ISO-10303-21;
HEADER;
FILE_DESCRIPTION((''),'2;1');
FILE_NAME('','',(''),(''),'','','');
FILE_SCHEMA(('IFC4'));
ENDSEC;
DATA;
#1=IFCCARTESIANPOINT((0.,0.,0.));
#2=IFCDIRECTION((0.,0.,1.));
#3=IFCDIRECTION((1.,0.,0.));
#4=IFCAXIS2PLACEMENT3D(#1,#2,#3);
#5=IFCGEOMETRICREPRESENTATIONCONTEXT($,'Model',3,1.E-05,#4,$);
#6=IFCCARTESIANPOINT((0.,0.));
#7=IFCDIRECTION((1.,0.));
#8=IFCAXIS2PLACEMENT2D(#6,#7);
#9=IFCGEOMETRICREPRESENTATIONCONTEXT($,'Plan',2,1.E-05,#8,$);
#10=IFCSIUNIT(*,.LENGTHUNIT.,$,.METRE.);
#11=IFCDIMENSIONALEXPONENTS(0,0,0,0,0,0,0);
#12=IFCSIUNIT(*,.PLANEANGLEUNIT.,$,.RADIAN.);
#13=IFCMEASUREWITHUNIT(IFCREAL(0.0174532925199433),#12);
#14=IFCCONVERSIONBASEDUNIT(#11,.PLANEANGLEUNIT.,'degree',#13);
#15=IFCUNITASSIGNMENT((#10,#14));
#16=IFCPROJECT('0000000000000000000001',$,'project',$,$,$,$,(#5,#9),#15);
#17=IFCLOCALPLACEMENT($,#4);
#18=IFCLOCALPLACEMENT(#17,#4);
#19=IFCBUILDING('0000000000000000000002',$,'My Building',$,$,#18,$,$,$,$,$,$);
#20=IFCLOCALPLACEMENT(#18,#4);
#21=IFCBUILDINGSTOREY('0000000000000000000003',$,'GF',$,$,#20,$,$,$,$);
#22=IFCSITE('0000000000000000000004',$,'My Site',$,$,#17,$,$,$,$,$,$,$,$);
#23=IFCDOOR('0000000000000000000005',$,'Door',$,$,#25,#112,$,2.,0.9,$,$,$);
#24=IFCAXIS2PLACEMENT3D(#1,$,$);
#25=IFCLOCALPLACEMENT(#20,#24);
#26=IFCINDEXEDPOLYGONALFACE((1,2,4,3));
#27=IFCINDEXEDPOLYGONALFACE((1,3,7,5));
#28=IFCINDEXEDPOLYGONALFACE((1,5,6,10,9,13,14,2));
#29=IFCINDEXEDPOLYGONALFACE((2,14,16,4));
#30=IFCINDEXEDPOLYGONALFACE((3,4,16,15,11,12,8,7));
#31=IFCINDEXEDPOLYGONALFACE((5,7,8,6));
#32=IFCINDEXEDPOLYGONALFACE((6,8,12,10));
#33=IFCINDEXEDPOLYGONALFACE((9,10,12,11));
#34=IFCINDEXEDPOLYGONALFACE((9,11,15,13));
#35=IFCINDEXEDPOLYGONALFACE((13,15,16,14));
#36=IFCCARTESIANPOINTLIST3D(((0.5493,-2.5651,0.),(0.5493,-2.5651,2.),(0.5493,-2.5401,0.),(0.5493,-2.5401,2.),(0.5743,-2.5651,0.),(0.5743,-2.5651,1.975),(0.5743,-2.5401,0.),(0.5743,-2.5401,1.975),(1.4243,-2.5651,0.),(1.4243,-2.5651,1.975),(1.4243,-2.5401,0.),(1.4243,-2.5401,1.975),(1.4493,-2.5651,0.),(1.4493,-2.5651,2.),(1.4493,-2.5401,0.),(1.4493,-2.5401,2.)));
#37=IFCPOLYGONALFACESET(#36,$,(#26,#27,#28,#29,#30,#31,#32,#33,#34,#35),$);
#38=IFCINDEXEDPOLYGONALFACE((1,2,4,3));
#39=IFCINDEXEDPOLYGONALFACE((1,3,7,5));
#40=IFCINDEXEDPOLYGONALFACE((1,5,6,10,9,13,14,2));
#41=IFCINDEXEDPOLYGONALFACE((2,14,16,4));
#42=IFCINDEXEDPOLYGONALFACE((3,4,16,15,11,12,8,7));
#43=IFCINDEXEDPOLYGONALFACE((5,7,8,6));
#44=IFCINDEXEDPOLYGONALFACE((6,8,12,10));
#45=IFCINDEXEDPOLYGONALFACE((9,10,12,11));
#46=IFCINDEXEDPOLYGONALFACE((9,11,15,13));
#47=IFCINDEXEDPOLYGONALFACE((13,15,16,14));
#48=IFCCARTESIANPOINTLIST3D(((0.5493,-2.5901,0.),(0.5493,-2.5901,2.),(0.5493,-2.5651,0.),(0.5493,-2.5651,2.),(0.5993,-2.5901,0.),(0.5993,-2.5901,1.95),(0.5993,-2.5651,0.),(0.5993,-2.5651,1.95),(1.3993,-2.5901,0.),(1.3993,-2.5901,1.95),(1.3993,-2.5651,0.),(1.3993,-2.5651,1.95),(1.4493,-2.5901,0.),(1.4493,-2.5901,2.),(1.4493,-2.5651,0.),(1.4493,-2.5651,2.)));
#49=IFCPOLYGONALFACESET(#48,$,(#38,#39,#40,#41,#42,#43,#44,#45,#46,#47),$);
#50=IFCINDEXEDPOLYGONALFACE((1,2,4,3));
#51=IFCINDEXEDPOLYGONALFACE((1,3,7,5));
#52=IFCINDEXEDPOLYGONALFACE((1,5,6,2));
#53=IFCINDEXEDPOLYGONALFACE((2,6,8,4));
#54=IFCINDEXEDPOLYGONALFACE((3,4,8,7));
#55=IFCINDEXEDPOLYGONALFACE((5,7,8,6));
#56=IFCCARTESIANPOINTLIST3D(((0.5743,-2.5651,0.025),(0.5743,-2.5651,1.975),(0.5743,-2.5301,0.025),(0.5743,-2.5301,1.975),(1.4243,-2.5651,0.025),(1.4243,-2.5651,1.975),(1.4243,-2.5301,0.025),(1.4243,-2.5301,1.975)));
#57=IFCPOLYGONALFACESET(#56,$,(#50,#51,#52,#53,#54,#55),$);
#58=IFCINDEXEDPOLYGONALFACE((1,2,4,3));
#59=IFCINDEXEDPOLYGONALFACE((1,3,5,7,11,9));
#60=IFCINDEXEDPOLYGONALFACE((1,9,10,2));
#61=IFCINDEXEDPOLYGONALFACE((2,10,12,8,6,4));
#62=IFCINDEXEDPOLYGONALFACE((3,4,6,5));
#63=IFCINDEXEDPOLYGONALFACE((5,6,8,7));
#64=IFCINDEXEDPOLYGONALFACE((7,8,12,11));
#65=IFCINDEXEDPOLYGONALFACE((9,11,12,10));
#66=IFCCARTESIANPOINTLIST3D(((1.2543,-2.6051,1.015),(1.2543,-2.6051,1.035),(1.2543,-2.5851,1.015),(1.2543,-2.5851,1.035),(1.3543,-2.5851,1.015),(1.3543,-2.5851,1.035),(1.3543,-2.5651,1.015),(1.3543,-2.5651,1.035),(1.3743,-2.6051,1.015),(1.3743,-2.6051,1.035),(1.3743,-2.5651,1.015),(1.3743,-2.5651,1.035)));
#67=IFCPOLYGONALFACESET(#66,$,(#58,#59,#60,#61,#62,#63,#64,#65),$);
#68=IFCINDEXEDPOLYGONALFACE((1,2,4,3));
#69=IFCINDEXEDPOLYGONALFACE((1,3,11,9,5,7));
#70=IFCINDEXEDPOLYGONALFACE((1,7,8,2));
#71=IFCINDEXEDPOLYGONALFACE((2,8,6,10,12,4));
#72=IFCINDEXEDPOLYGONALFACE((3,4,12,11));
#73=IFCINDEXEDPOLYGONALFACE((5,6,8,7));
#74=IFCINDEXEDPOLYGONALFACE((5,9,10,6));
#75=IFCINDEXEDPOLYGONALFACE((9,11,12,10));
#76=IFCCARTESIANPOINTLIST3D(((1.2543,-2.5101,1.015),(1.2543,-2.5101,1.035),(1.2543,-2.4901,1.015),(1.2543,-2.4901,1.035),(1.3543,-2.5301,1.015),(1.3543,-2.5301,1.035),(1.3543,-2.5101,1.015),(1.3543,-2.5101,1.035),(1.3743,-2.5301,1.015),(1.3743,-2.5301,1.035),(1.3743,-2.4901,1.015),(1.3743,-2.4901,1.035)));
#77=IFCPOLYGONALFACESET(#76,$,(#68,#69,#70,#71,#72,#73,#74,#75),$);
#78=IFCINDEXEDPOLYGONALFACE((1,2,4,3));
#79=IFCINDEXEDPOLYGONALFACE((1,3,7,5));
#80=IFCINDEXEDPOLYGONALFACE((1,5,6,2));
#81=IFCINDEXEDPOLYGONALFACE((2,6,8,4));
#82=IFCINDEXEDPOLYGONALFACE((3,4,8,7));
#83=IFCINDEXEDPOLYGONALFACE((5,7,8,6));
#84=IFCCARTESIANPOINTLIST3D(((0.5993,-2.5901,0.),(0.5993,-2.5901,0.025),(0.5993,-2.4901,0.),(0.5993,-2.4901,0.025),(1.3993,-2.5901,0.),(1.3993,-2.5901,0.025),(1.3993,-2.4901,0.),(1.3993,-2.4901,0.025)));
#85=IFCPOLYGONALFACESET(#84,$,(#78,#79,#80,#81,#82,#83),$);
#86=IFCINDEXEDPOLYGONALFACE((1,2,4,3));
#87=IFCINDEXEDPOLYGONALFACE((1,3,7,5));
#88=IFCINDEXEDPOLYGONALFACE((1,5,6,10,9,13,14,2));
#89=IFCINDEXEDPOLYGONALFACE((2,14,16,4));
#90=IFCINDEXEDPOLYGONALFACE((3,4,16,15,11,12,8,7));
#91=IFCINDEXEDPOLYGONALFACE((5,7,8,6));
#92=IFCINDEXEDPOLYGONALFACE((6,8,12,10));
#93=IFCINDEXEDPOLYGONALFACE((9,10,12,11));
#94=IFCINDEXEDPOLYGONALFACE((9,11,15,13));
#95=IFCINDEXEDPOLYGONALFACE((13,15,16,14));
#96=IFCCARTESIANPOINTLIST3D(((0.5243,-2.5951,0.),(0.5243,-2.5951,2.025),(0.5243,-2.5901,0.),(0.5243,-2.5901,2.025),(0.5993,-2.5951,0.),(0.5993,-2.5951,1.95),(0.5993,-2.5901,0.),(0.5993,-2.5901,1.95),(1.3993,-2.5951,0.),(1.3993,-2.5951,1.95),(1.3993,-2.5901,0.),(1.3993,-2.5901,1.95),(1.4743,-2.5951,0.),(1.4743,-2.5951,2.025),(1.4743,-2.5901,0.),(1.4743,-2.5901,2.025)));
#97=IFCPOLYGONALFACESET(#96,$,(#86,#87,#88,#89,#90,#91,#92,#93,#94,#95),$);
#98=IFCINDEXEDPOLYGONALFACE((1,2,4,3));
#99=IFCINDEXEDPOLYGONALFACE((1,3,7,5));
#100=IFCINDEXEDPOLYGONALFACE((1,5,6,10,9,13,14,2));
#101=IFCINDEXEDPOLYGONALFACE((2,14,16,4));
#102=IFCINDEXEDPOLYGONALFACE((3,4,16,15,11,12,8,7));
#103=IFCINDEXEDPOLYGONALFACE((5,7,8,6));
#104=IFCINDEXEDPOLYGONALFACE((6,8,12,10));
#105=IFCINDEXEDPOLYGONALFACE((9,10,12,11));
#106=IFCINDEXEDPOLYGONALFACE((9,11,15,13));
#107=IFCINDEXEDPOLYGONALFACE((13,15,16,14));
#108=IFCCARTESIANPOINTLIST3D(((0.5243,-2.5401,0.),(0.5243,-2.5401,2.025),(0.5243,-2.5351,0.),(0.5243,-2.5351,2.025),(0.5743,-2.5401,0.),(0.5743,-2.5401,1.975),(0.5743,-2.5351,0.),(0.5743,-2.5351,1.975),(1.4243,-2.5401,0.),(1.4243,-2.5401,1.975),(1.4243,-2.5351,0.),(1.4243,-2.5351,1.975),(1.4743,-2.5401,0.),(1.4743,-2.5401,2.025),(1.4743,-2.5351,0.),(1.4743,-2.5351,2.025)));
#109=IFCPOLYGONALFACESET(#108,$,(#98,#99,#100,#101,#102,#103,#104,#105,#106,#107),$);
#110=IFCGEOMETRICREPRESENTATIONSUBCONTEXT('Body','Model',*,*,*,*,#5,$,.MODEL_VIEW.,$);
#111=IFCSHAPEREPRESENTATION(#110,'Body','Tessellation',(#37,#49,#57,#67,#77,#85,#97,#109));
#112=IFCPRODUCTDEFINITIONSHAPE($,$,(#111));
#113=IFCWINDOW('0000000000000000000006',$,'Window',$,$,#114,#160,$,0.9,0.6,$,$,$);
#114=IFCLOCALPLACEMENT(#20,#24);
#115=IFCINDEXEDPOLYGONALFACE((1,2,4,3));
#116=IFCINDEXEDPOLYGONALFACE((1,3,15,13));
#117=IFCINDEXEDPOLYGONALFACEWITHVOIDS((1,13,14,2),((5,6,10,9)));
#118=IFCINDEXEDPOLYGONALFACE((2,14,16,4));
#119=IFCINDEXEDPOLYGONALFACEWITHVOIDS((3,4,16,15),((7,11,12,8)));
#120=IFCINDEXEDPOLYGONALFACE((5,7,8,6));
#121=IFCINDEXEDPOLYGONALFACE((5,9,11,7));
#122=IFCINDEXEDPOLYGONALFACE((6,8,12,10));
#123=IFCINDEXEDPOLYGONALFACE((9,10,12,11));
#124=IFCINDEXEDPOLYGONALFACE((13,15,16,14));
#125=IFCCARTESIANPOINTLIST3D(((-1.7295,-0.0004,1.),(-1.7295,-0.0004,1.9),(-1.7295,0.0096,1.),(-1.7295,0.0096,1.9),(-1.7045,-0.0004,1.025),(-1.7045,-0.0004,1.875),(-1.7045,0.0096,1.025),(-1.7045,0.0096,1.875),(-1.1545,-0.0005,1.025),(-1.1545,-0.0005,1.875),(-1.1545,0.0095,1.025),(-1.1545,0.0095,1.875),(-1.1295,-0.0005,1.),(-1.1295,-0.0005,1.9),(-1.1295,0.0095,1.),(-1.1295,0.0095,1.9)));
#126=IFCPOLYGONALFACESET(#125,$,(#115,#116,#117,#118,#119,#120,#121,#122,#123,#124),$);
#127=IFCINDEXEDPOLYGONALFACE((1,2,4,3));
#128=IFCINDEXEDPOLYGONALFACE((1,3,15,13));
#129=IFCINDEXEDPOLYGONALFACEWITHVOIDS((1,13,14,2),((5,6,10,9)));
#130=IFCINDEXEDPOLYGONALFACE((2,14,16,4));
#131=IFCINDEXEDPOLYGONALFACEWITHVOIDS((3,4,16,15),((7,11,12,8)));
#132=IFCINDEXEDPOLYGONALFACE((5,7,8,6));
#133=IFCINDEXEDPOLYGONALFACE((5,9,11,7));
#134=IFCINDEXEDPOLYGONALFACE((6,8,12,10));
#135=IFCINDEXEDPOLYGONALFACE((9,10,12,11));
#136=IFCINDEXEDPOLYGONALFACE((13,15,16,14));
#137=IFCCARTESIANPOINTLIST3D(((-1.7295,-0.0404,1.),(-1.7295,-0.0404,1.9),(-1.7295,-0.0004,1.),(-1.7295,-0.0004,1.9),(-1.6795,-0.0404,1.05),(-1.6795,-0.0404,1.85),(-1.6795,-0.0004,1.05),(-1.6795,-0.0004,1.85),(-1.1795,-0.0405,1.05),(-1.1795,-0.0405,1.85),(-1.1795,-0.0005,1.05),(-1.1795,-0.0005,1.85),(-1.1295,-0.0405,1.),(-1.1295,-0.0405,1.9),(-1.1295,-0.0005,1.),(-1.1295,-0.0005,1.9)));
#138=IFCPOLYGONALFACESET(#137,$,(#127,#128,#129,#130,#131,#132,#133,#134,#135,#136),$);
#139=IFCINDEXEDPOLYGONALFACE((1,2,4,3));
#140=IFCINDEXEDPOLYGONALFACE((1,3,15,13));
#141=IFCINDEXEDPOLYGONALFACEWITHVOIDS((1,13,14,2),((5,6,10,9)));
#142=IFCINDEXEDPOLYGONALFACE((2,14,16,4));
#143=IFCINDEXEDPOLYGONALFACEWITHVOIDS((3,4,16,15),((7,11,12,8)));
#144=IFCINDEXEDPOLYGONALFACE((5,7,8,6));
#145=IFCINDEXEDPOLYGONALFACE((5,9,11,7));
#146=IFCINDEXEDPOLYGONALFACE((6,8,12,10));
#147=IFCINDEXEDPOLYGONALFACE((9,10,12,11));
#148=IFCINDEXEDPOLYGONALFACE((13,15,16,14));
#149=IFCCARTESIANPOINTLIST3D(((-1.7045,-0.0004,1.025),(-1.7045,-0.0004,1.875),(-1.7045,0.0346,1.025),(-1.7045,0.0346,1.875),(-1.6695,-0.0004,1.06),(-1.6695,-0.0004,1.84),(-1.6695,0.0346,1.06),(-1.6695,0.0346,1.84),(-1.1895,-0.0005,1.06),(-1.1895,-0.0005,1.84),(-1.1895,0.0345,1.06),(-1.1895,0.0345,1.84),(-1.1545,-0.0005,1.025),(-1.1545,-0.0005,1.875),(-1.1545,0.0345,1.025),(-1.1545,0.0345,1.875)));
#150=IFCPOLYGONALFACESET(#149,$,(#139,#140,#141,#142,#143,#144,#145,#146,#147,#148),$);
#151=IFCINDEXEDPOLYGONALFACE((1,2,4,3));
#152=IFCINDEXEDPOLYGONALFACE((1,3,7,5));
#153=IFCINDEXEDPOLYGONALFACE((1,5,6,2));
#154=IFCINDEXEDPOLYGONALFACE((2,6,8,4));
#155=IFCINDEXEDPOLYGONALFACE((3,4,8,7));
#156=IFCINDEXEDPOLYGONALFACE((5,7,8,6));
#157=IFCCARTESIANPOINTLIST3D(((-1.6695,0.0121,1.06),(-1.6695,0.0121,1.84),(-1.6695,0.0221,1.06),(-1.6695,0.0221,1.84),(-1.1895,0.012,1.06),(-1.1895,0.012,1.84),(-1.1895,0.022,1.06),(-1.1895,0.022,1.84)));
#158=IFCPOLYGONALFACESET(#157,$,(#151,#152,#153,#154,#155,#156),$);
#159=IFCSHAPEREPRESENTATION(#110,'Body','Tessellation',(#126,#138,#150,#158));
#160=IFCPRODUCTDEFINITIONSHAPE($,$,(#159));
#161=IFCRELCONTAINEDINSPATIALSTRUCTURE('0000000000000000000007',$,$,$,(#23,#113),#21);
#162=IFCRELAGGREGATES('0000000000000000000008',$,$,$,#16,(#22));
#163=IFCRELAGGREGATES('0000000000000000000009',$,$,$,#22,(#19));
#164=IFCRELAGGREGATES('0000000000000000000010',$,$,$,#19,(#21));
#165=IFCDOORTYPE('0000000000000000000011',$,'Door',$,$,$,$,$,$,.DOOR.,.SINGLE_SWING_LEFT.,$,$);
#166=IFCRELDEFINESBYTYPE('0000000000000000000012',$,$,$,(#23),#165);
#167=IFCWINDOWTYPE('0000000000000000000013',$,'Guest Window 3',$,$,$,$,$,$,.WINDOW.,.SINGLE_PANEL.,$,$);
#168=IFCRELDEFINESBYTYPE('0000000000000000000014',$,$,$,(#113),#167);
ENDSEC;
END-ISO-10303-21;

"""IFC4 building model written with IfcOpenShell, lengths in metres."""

from ifc_helpers import new_model, entity, si_unit, converted_unit, frame, origin_with_axes, origin_2d_with_axis, place, context, subcontext, project, spatial, line, indexed_curve, outline, extrude, shape, source, transform, mapped, type_object, type_shapes, element, save


model = new_model("IFC4")

# Units and contexts
model_context = context("Model", 3, precision=1e-05, world=origin_with_axes())
plan_context = context("Plan", 2, precision=1e-05, world=origin_2d_with_axis())
body_context_1 = subcontext(model_context, "Body", "Model", "MODEL_VIEW")
body_context_2 = subcontext(plan_context, "Body", "Plan", "PLAN_VIEW")
ifc_project = project(units=[si_unit("LENGTHUNIT", "METRE"), converted_unit("PLANEANGLEUNIT", "degree", entity("IfcReal", 0.0174532925199433), si_unit("PLANEANGLEUNIT", "RADIAN"), dimensions=[0, 0, 0, 0, 0, 0, 0])], contexts=[model_context, plan_context])

# Site, building, storey
site_placement = place(None, origin_with_axes())
site = spatial("IfcSite", under=ifc_project, at=site_placement, Name="My Site")
building_placement = place(site_placement, origin_with_axes())
building = spatial("IfcBuilding", under=site, at=building_placement, Name="My Building")
storey_placement = place(building_placement, origin_with_axes())
storey = spatial("IfcBuildingStorey", under=building, at=storey_placement, Name="GF")

# Shared definitions
door_type = type_object("IfcDoorType", Name="Door", OperationType="SINGLE_SWING_LEFT", PredefinedType="DOOR")
shared_shape_1 = source(origin_with_axes(), body_context_1, "Body", "SweptSolid", [
    extrude(outline(indexed_curve([(0.0, 0.0), (0.0, 2.0), (0.9, 2.0), (0.9, 0.0), (0.875, 0.0), (0.875, 1.975), (0.025, 1.975), (0.025, 0.0)], segments=[line(1, 2, 3, 4, 5, 6, 7, 8, 1)])), frame((0.0, 0.025, 0.0), z_axis=(0.0, -1.0, 0.0), x_axis=(1.0, 0.0, 0.0)), (0.0, 0.0, -1.0), 0.025),
    extrude(outline(indexed_curve([(0.0, 0.0), (0.0, 2.0), (0.9, 2.0), (0.9, 0.0), (0.85, 0.0), (0.85, 1.95), (0.05, 1.95), (0.05, 0.0)], segments=[line(1, 2, 3, 4, 5, 6, 7, 8, 1)])), frame((0.0, 0.0, 0.0), z_axis=(0.0, -1.0, 0.0), x_axis=(1.0, 0.0, 0.0)), (0.0, 0.0, -1.0), 0.025),
    extrude(outline(indexed_curve([(0.0, 0.0), (0.85, 0.0), (0.85, 0.035), (0.0, 0.035)], segments=[line(1, 2, 3, 4, 1)])), frame((0.025, 0.025, 0.025), z_axis=(0.0, 0.0, 1.0), x_axis=(1.0, 0.0, 0.0)), (0.0, 0.0, 1.0), 1.95),
    extrude(outline(indexed_curve([(0.0, 0.0), (0.0, -0.04), (-0.12, -0.04), (-0.12, -0.02), (-0.02, -0.02), (-0.02, 0.0)], segments=[line(1, 2, 3, 4, 5, 6, 1)])), frame((0.825, 0.025, 1.015), z_axis=(0.0, 0.0, 1.0), x_axis=(1.0, 0.0, 0.0)), (0.0, 0.0, 1.0), 0.02),
    extrude(outline(indexed_curve([(0.0, 0.0), (0.0, 0.04), (-0.12, 0.04), (-0.12, 0.02), (-0.02, 0.02), (-0.02, 0.0)], segments=[line(1, 2, 3, 4, 5, 6, 1)])), frame((0.825, 0.06, 1.015), z_axis=(0.0, 0.0, 1.0), x_axis=(1.0, 0.0, 0.0)), (0.0, 0.0, 1.0), 0.02),
    extrude(outline(indexed_curve([(0.0, 0.0), (0.8, 0.0), (0.8, 0.1), (0.0, 0.1)], segments=[line(1, 2, 3, 4, 1)])), frame((0.05, 0.0, 0.0), z_axis=(0.0, 0.0, 1.0), x_axis=(1.0, 0.0, 0.0)), (0.0, 0.0, 1.0), 0.025),
    extrude(outline(indexed_curve([(0.0, 0.0), (0.0, 2.025), (0.95, 2.025), (0.95, 0.0), (0.875, 0.0), (0.875, 1.95), (0.075, 1.95), (0.075, 0.0)], segments=[line(1, 2, 3, 4, 5, 6, 7, 8, 1)])), frame((-0.025, -0.005, 0.0), z_axis=(0.0, -1.0, 0.0), x_axis=(1.0, 0.0, 0.0)), (0.0, 0.0, -1.0), 0.005),
    extrude(outline(indexed_curve([(0.0, 0.0), (0.0, 2.025), (0.95, 2.025), (0.95, 0.0), (0.9, 0.0), (0.9, 1.975), (0.05, 1.975), (0.05, 0.0)], segments=[line(1, 2, 3, 4, 5, 6, 7, 8, 1)])), frame((-0.025, 0.05, 0.0), z_axis=(0.0, -1.0, 0.0), x_axis=(1.0, 0.0, 0.0)), (0.0, 0.0, -1.0), 0.005),
])
shared_shape_2 = source(origin_with_axes(), body_context_2, "Body", "Curve2D", [
    entity("IfcIndexedPolyCurve", entity("IfcCartesianPointList2D", [[0.0, 0.0], [0.0, 0.05], [0.025, 0.05], [0.025, 0.025], [0.05, 0.025], [0.05, 0.0]]), [entity("IfcLineIndex", [1, 2, 3, 4, 5, 6, 1])]),
    entity("IfcIndexedPolyCurve", entity("IfcCartesianPointList2D", [[0.9, 0.0], [0.9, 0.05], [0.875, 0.05], [0.875, 0.025], [0.85, 0.025], [0.85, 0.0]]), [entity("IfcLineIndex", [1, 2, 3, 4, 5, 6, 1])]),
    entity("IfcTrimmedCurve", entity("IfcEllipse", entity("IfcAxis2Placement2D", entity("IfcCartesianPoint", [0.06, 0.05]), entity("IfcDirection", [1.0, 0.0])), 0.815, 0.85), [entity("IfcCartesianPoint", [0.875, 0.05])], [entity("IfcCartesianPoint", [0.06, 0.9])], True, "CARTESIAN"),
    entity("IfcIndexedPolyCurve", entity("IfcCartesianPointList2D", [[0.025, 0.05], [0.06, 0.05], [0.06, 0.9], [0.025, 0.9]]), [entity("IfcLineIndex", [1, 2, 3, 4, 1])]),
])
type_shapes(door_type, [shared_shape_1, shared_shape_2])

# Door
door_1_placement = place(storey_placement, frame((0.5493, -2.5901, 0.0), z_axis=(0.0, 0.0, 1.0), x_axis=(1.0, 0.0, 0.0)))
element("IfcDoor", 1, at=door_1_placement, inside=storey, type_object=door_type, Name="Door", OverallHeight=2.0, OverallWidth=0.9, shapes=[
    shape(body_context_1, "Body", "MappedRepresentation", [mapped(shared_shape_1, transform((0.0, 0.0, 0.0), x_axis=(1.0, 0.0, 0.0), y_axis=(0.0, 1.0, 0.0), z_axis=(0.0, 0.0, 1.0), scale=1.0))]),
    shape(body_context_2, "Body", "MappedRepresentation", [mapped(shared_shape_2, transform((0.0, 0.0, 0.0), x_axis=(1.0, 0.0, 0.0), y_axis=(0.0, 1.0, 0.0), z_axis=(0.0, 0.0, 1.0), scale=1.0))]),
])

# Window
window_type_1 = type_object("IfcWindowType", Name="Guest Window 3", PartitioningType="SINGLE_PANEL", PredefinedType="WINDOW")
shared_shape_3 = source(origin_with_axes(), body_context_1, "Body", "SweptSolid", [
    extrude(outline(indexed_curve([(0.0, 0.0), (0.6, 0.0), (0.6, 0.9), (0.0, 0.9)], segments=[line(1, 2, 3, 4, 1)]), holes=[indexed_curve([(0.025, 0.025), (0.575, 0.025), (0.575, 0.875), (0.025, 0.875)], segments=[line(1, 2, 3, 4, 1)])]), frame((0.0, 0.09, 0.0), z_axis=(0.0, -1.0, 0.0), x_axis=(1.0, 0.0, 0.0)), (0.0, 0.0, -1.0), 0.01),
    extrude(outline(indexed_curve([(0.0, 0.0), (0.6, 0.0), (0.6, 0.9), (0.0, 0.9)], segments=[line(1, 2, 3, 4, 1)]), holes=[indexed_curve([(0.05, 0.05), (0.55, 0.05), (0.55, 0.85), (0.05, 0.85)], segments=[line(1, 2, 3, 4, 1)])]), frame((0.0, 0.05, 0.0), z_axis=(0.0, -1.0, 0.0), x_axis=(1.0, 0.0, 0.0)), (0.0, 0.0, -1.0), 0.04),
    extrude(outline(indexed_curve([(0.0, 0.0), (0.55, 0.0), (0.55, 0.85), (0.0, 0.85)], segments=[line(1, 2, 3, 4, 1)]), holes=[indexed_curve([(0.035, 0.035), (0.515, 0.035), (0.515, 0.815), (0.035, 0.815)], segments=[line(1, 2, 3, 4, 1)])]), frame((0.025, 0.09, 0.025), z_axis=(0.0, -1.0, 0.0), x_axis=(1.0, 0.0, 0.0)), (0.0, 0.0, -1.0), 0.035),
    extrude(outline(indexed_curve([(0.035, 0.035), (0.515, 0.035), (0.515, 0.815), (0.035, 0.815)], segments=[line(1, 2, 3, 4, 1)])), frame((0.025, 0.1025, 0.025), z_axis=(0.0, -1.0, 0.0), x_axis=(1.0, 0.0, 0.0)), (0.0, 0.0, -1.0), 0.01),
])
shared_shape_4 = source(origin_with_axes(), body_context_2, "Body", "Curve2D", [
    entity("IfcIndexedPolyCurve", entity("IfcCartesianPointList2D", [[0.05, 0.05], [0.55, 0.05]])),
    entity("IfcIndexedPolyCurve", entity("IfcCartesianPointList2D", [[0.0, 0.1], [0.025, 0.1], [0.025, 0.09], [0.05, 0.09], [0.05, 0.05], [0.0, 0.05]]), [entity("IfcLineIndex", [1, 2, 3, 4, 5, 6, 1])]),
    entity("IfcIndexedPolyCurve", entity("IfcCartesianPointList2D", [[0.6, 0.1], [0.575, 0.1], [0.575, 0.09], [0.55, 0.09], [0.55, 0.05], [0.6, 0.05]]), [entity("IfcLineIndex", [1, 2, 3, 4, 5, 6, 1])]),
    entity("IfcIndexedPolyCurve", entity("IfcCartesianPointList2D", [[0.025, 0.09], [0.06, 0.09], [0.06, 0.125], [0.025, 0.125]]), [entity("IfcLineIndex", [1, 2, 3, 4, 1])]),
    entity("IfcIndexedPolyCurve", entity("IfcCartesianPointList2D", [[0.575, 0.09], [0.54, 0.09], [0.54, 0.125], [0.575, 0.125]]), [entity("IfcLineIndex", [1, 2, 3, 4, 1])]),
    entity("IfcIndexedPolyCurve", entity("IfcCartesianPointList2D", [[0.06, 0.09], [0.54, 0.09]])),
    entity("IfcIndexedPolyCurve", entity("IfcCartesianPointList2D", [[0.06, 0.125], [0.54, 0.125]])),
    entity("IfcIndexedPolyCurve", entity("IfcCartesianPointList2D", [[0.06, 0.1075], [0.54, 0.1075]])),
])
type_shapes(window_type_1, [shared_shape_3, shared_shape_4])
placement_1 = place(storey_placement, frame((-2.7734, -0.0901, 0.0), z_axis=(0.0, 0.0, 1.0), x_axis=(1.0, -0.000264, 0.0)))
placement_2 = place(placement_1, frame((1.0439, 0.0, 1.0), z_axis=(0.0, 0.0, 1.0), x_axis=(1.0, 0.0, 0.0)))
window_1_placement = place(placement_2, frame((0.0, 0.0, 0.0), z_axis=(0.0, 0.0, 1.0), x_axis=(1.0, 0.0, 0.0)))
element("IfcWindow", 2, at=window_1_placement, inside=storey, type_object=window_type_1, Name="Window", OverallHeight=0.9, OverallWidth=0.6, shapes=[
    shape(body_context_1, "Body", "MappedRepresentation", [mapped(shared_shape_3, transform((0.0, 0.0, 0.0), x_axis=(1.0, 0.0, 0.0), y_axis=(0.0, 1.0, 0.0), z_axis=(0.0, 0.0, 1.0), scale=1.0))]),
    shape(body_context_2, "Body", "MappedRepresentation", [mapped(shared_shape_4, transform((0.0, 0.0, 0.0), x_axis=(1.0, 0.0, 0.0), y_axis=(0.0, 1.0, 0.0), z_axis=(0.0, 0.0, 1.0), scale=1.0))]),
])

save(model, "model.ifc")
